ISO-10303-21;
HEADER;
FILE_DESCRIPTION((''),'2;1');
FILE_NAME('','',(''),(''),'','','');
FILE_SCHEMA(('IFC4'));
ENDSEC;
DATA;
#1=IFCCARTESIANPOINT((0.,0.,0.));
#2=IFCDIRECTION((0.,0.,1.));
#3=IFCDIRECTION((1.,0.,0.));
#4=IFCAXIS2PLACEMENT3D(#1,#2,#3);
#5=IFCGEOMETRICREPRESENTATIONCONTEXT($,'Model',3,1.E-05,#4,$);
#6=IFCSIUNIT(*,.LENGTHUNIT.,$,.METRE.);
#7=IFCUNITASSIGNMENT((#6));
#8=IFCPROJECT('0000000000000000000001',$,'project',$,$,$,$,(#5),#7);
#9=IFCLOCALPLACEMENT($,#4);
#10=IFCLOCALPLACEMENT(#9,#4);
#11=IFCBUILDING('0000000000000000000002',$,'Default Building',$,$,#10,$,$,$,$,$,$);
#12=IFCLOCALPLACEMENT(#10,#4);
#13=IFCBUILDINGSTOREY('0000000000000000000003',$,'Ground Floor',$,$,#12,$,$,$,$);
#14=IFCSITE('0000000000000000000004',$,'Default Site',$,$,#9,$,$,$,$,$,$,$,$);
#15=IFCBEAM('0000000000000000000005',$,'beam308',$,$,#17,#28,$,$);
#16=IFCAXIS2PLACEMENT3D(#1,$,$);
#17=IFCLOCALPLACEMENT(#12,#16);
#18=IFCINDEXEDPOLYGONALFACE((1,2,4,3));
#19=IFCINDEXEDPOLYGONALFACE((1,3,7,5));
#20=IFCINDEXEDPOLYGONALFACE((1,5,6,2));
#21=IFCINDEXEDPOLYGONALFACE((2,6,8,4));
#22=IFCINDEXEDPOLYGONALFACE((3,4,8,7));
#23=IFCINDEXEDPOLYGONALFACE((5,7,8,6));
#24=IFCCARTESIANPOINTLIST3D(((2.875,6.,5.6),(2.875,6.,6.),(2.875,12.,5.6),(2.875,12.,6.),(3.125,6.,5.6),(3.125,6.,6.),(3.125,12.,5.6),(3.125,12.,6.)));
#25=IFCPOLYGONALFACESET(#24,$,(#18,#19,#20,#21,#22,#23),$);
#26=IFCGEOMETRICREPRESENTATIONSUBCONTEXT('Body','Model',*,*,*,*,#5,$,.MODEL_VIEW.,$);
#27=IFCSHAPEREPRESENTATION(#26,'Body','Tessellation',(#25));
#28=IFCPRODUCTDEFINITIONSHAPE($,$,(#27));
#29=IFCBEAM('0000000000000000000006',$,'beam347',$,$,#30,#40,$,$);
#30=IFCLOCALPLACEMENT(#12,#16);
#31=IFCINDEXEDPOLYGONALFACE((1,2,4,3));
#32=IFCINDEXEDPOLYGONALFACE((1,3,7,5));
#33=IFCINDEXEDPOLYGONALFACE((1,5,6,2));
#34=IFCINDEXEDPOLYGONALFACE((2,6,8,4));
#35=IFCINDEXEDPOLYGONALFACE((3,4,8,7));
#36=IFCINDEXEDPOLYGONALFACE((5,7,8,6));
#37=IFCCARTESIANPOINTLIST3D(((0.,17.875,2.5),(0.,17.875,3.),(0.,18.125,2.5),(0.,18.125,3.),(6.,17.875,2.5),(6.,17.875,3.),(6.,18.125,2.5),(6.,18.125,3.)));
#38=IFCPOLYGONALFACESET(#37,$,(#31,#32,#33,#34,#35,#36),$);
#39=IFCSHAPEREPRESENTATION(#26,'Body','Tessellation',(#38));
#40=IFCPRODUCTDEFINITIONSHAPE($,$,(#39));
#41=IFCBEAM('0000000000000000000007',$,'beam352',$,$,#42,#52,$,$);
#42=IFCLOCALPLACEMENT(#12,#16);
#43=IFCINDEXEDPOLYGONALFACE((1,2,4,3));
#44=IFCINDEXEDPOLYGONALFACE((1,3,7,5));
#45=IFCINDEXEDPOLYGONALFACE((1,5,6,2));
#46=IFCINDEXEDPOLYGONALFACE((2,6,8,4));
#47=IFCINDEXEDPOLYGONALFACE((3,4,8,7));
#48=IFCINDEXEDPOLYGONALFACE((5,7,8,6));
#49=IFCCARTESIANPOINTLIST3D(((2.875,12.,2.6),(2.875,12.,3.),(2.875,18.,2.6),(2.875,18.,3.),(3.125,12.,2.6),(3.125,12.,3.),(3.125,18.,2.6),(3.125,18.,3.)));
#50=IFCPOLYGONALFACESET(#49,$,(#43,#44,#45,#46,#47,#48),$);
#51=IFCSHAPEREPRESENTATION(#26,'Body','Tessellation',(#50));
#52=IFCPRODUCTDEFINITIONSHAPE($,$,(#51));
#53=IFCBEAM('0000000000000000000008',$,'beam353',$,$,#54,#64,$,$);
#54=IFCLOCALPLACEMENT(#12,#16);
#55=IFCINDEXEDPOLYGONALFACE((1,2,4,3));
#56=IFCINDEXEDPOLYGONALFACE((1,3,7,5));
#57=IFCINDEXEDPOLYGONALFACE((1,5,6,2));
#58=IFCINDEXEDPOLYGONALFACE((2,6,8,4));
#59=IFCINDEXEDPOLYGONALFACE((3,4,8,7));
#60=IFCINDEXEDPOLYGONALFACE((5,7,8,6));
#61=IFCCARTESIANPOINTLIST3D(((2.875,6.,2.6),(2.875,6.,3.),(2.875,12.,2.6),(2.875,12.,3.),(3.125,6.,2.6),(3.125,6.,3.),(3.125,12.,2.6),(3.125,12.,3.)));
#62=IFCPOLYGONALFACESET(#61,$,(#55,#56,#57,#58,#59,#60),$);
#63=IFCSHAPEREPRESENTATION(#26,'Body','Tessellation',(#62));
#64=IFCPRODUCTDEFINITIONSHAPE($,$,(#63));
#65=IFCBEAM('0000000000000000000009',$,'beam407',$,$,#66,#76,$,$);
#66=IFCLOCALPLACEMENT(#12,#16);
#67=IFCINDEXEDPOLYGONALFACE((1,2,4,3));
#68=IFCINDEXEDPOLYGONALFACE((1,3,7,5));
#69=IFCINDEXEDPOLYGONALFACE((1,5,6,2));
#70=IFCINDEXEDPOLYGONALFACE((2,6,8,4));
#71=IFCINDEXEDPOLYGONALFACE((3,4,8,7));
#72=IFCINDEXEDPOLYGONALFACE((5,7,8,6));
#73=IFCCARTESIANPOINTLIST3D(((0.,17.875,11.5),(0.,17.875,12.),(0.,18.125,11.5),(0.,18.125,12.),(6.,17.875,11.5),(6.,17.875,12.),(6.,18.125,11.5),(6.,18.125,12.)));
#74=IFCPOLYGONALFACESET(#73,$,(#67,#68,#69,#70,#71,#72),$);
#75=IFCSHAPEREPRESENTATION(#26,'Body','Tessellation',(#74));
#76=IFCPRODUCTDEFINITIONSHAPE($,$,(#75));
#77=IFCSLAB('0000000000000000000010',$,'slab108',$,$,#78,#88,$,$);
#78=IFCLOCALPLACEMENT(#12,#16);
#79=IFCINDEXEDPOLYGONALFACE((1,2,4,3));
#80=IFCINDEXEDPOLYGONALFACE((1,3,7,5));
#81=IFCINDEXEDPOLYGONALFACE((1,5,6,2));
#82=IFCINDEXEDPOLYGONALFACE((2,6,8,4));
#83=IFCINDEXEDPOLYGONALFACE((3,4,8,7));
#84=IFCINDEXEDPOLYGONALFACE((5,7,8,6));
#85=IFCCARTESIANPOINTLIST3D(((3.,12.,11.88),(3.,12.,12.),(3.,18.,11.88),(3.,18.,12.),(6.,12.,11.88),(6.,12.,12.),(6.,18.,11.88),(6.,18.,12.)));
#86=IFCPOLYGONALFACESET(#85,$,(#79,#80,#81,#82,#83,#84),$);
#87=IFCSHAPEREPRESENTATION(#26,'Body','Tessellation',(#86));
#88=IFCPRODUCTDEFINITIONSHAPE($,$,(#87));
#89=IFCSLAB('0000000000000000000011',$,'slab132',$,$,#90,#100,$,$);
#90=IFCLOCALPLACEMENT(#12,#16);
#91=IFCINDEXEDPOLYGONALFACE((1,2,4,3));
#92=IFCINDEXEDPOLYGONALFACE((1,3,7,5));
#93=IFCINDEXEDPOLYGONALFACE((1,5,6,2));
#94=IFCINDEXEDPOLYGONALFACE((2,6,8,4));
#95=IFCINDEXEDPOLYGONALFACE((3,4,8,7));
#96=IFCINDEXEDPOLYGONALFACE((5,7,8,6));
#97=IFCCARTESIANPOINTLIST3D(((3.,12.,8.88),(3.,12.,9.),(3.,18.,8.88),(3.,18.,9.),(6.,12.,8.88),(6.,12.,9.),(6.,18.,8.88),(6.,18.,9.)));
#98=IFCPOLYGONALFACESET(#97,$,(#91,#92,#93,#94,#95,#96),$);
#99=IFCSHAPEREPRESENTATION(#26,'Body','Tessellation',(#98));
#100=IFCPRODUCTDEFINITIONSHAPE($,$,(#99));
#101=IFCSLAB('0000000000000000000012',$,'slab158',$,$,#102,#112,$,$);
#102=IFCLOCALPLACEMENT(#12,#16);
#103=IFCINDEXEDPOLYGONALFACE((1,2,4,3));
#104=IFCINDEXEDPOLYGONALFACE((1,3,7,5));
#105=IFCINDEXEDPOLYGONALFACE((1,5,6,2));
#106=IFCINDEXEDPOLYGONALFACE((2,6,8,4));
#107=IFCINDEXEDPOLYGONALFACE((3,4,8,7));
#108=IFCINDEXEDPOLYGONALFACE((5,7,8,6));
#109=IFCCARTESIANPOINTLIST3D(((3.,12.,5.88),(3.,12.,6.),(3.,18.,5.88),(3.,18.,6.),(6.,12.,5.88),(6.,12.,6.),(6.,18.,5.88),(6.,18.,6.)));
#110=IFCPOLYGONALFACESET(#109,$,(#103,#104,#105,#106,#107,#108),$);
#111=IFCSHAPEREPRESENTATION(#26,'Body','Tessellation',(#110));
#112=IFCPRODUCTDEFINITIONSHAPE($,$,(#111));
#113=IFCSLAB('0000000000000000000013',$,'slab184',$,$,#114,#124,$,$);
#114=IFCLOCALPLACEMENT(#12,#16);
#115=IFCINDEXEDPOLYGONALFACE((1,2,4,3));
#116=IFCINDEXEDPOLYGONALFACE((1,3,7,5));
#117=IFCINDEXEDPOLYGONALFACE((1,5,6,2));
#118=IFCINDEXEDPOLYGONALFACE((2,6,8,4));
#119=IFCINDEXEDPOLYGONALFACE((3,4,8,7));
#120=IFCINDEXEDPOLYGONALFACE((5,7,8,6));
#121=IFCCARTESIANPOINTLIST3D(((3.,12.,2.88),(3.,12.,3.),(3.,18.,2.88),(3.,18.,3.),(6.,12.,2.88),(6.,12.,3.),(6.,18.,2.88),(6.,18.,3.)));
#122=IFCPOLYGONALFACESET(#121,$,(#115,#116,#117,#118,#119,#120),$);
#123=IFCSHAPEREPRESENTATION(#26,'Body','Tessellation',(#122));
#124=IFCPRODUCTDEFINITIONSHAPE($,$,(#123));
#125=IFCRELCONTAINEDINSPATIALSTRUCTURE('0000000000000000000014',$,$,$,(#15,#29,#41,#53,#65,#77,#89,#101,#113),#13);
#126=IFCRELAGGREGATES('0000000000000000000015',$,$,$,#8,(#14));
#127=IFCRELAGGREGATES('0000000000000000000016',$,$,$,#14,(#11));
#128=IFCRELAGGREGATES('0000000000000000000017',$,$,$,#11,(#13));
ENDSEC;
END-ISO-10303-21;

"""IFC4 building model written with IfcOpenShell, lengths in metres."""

from ifc_helpers import new_model, si_unit, frame, origin_with_axes, place, context, subcontext, project, spatial, indexed_curve, outline, extrude, element, save


model = new_model("IFC4")

# Units and contexts
model_context = context("Model", 3, precision=1e-05, world=origin_with_axes())
body_context = subcontext(model_context, "Body", "Model", "MODEL_VIEW")
ifc_project = project(units=[si_unit("LENGTHUNIT", "METRE")], contexts=[model_context])

# Site, building, storey
site_placement = place(None, origin_with_axes())
site = spatial("IfcSite", under=ifc_project, at=site_placement, Name="Default Site")
building_placement = place(site_placement, origin_with_axes())
building = spatial("IfcBuilding", under=site, at=building_placement, Name="Default Building")
storey_placement = place(building_placement, origin_with_axes())
storey = spatial("IfcBuildingStorey", under=building, at=storey_placement, Name="Ground Floor")

# Beams
for number, where, z_axis, x_axis, name in (
    (1, (2.875, 12.0, 5.6), (0.0, 0.0, 1.0), (0.0, -1.0, 0.0), "beam308"),
):
    element("IfcBeam", number, at=place(storey_placement, frame(where, z_axis=z_axis, x_axis=x_axis)), inside=storey, Name=name, context=body_context, shape_type="SweptSolid", body=[
        extrude(outline(indexed_curve([(0.0, 0.0), (0.0, 0.25), (6.0, 0.25), (6.0, 0.0), (0.0, 0.0)], self_intersect=False)), origin_with_axes(), (0.0, 0.0, 1.0), 0.4),
    ])
beam_1_placement = place(storey_placement, frame((0.0, 17.875, 2.5), z_axis=(0.0, 0.0, 1.0), x_axis=(1.0, 0.0, 0.0)))
element("IfcBeam", 2, at=beam_1_placement, inside=storey, Name="beam347", context=body_context, shape_type="SweptSolid", body=[
    extrude(outline(indexed_curve([(0.0, 0.0), (0.0, 0.25), (6.0, 0.25), (6.0, 0.0), (0.0, 0.0)], self_intersect=False)), origin_with_axes(), (0.0, 0.0, 1.0), 0.5),
])
for number, where, z_axis, x_axis, name in (
    (3, (2.875, 18.0, 2.6), (0.0, 0.0, 1.0), (0.0, -1.0, 0.0), "beam352"),
    (4, (2.875, 12.0, 2.6), (0.0, 0.0, 1.0), (0.0, -1.0, 0.0), "beam353"),
):
    element("IfcBeam", number, at=place(storey_placement, frame(where, z_axis=z_axis, x_axis=x_axis)), inside=storey, Name=name, context=body_context, shape_type="SweptSolid", body=[
        extrude(outline(indexed_curve([(0.0, 0.0), (0.0, 0.25), (6.0, 0.25), (6.0, 0.0), (0.0, 0.0)], self_intersect=False)), origin_with_axes(), (0.0, 0.0, 1.0), 0.4),
    ])
beam_2_placement = place(storey_placement, frame((0.0, 17.875, 11.5), z_axis=(0.0, 0.0, 1.0), x_axis=(1.0, 0.0, 0.0)))
element("IfcBeam", 5, at=beam_2_placement, inside=storey, Name="beam407", context=body_context, shape_type="SweptSolid", body=[
    extrude(outline(indexed_curve([(0.0, 0.0), (0.0, 0.25), (6.0, 0.25), (6.0, 0.0), (0.0, 0.0)], self_intersect=False)), origin_with_axes(), (0.0, 0.0, 1.0), 0.5),
])

# Slabs
for number, where, z_axis, x_axis, name in (
    (6, (3.0, 12.0, 11.88), (0.0, 0.0, 1.0), (1.0, 0.0, 0.0), "slab108"),
    (7, (3.0, 12.0, 8.88), (0.0, 0.0, 1.0), (1.0, 0.0, 0.0), "slab132"),
    (8, (3.0, 12.0, 5.88), (0.0, 0.0, 1.0), (1.0, 0.0, 0.0), "slab158"),
    (9, (3.0, 12.0, 2.88), (0.0, 0.0, 1.0), (1.0, 0.0, 0.0), "slab184"),
):
    element("IfcSlab", number, at=place(storey_placement, frame(where, z_axis=z_axis, x_axis=x_axis)), inside=storey, Name=name, context=body_context, shape_type="SweptSolid", body=[
        extrude(outline(indexed_curve([(0.0, 0.0), (0.0, 6.0), (3.0, 6.0), (3.0, 0.0), (0.0, 0.0)], self_intersect=False)), origin_with_axes(), (0.0, 0.0, 1.0), 0.12),
    ])

save(model, "model.ifc")
